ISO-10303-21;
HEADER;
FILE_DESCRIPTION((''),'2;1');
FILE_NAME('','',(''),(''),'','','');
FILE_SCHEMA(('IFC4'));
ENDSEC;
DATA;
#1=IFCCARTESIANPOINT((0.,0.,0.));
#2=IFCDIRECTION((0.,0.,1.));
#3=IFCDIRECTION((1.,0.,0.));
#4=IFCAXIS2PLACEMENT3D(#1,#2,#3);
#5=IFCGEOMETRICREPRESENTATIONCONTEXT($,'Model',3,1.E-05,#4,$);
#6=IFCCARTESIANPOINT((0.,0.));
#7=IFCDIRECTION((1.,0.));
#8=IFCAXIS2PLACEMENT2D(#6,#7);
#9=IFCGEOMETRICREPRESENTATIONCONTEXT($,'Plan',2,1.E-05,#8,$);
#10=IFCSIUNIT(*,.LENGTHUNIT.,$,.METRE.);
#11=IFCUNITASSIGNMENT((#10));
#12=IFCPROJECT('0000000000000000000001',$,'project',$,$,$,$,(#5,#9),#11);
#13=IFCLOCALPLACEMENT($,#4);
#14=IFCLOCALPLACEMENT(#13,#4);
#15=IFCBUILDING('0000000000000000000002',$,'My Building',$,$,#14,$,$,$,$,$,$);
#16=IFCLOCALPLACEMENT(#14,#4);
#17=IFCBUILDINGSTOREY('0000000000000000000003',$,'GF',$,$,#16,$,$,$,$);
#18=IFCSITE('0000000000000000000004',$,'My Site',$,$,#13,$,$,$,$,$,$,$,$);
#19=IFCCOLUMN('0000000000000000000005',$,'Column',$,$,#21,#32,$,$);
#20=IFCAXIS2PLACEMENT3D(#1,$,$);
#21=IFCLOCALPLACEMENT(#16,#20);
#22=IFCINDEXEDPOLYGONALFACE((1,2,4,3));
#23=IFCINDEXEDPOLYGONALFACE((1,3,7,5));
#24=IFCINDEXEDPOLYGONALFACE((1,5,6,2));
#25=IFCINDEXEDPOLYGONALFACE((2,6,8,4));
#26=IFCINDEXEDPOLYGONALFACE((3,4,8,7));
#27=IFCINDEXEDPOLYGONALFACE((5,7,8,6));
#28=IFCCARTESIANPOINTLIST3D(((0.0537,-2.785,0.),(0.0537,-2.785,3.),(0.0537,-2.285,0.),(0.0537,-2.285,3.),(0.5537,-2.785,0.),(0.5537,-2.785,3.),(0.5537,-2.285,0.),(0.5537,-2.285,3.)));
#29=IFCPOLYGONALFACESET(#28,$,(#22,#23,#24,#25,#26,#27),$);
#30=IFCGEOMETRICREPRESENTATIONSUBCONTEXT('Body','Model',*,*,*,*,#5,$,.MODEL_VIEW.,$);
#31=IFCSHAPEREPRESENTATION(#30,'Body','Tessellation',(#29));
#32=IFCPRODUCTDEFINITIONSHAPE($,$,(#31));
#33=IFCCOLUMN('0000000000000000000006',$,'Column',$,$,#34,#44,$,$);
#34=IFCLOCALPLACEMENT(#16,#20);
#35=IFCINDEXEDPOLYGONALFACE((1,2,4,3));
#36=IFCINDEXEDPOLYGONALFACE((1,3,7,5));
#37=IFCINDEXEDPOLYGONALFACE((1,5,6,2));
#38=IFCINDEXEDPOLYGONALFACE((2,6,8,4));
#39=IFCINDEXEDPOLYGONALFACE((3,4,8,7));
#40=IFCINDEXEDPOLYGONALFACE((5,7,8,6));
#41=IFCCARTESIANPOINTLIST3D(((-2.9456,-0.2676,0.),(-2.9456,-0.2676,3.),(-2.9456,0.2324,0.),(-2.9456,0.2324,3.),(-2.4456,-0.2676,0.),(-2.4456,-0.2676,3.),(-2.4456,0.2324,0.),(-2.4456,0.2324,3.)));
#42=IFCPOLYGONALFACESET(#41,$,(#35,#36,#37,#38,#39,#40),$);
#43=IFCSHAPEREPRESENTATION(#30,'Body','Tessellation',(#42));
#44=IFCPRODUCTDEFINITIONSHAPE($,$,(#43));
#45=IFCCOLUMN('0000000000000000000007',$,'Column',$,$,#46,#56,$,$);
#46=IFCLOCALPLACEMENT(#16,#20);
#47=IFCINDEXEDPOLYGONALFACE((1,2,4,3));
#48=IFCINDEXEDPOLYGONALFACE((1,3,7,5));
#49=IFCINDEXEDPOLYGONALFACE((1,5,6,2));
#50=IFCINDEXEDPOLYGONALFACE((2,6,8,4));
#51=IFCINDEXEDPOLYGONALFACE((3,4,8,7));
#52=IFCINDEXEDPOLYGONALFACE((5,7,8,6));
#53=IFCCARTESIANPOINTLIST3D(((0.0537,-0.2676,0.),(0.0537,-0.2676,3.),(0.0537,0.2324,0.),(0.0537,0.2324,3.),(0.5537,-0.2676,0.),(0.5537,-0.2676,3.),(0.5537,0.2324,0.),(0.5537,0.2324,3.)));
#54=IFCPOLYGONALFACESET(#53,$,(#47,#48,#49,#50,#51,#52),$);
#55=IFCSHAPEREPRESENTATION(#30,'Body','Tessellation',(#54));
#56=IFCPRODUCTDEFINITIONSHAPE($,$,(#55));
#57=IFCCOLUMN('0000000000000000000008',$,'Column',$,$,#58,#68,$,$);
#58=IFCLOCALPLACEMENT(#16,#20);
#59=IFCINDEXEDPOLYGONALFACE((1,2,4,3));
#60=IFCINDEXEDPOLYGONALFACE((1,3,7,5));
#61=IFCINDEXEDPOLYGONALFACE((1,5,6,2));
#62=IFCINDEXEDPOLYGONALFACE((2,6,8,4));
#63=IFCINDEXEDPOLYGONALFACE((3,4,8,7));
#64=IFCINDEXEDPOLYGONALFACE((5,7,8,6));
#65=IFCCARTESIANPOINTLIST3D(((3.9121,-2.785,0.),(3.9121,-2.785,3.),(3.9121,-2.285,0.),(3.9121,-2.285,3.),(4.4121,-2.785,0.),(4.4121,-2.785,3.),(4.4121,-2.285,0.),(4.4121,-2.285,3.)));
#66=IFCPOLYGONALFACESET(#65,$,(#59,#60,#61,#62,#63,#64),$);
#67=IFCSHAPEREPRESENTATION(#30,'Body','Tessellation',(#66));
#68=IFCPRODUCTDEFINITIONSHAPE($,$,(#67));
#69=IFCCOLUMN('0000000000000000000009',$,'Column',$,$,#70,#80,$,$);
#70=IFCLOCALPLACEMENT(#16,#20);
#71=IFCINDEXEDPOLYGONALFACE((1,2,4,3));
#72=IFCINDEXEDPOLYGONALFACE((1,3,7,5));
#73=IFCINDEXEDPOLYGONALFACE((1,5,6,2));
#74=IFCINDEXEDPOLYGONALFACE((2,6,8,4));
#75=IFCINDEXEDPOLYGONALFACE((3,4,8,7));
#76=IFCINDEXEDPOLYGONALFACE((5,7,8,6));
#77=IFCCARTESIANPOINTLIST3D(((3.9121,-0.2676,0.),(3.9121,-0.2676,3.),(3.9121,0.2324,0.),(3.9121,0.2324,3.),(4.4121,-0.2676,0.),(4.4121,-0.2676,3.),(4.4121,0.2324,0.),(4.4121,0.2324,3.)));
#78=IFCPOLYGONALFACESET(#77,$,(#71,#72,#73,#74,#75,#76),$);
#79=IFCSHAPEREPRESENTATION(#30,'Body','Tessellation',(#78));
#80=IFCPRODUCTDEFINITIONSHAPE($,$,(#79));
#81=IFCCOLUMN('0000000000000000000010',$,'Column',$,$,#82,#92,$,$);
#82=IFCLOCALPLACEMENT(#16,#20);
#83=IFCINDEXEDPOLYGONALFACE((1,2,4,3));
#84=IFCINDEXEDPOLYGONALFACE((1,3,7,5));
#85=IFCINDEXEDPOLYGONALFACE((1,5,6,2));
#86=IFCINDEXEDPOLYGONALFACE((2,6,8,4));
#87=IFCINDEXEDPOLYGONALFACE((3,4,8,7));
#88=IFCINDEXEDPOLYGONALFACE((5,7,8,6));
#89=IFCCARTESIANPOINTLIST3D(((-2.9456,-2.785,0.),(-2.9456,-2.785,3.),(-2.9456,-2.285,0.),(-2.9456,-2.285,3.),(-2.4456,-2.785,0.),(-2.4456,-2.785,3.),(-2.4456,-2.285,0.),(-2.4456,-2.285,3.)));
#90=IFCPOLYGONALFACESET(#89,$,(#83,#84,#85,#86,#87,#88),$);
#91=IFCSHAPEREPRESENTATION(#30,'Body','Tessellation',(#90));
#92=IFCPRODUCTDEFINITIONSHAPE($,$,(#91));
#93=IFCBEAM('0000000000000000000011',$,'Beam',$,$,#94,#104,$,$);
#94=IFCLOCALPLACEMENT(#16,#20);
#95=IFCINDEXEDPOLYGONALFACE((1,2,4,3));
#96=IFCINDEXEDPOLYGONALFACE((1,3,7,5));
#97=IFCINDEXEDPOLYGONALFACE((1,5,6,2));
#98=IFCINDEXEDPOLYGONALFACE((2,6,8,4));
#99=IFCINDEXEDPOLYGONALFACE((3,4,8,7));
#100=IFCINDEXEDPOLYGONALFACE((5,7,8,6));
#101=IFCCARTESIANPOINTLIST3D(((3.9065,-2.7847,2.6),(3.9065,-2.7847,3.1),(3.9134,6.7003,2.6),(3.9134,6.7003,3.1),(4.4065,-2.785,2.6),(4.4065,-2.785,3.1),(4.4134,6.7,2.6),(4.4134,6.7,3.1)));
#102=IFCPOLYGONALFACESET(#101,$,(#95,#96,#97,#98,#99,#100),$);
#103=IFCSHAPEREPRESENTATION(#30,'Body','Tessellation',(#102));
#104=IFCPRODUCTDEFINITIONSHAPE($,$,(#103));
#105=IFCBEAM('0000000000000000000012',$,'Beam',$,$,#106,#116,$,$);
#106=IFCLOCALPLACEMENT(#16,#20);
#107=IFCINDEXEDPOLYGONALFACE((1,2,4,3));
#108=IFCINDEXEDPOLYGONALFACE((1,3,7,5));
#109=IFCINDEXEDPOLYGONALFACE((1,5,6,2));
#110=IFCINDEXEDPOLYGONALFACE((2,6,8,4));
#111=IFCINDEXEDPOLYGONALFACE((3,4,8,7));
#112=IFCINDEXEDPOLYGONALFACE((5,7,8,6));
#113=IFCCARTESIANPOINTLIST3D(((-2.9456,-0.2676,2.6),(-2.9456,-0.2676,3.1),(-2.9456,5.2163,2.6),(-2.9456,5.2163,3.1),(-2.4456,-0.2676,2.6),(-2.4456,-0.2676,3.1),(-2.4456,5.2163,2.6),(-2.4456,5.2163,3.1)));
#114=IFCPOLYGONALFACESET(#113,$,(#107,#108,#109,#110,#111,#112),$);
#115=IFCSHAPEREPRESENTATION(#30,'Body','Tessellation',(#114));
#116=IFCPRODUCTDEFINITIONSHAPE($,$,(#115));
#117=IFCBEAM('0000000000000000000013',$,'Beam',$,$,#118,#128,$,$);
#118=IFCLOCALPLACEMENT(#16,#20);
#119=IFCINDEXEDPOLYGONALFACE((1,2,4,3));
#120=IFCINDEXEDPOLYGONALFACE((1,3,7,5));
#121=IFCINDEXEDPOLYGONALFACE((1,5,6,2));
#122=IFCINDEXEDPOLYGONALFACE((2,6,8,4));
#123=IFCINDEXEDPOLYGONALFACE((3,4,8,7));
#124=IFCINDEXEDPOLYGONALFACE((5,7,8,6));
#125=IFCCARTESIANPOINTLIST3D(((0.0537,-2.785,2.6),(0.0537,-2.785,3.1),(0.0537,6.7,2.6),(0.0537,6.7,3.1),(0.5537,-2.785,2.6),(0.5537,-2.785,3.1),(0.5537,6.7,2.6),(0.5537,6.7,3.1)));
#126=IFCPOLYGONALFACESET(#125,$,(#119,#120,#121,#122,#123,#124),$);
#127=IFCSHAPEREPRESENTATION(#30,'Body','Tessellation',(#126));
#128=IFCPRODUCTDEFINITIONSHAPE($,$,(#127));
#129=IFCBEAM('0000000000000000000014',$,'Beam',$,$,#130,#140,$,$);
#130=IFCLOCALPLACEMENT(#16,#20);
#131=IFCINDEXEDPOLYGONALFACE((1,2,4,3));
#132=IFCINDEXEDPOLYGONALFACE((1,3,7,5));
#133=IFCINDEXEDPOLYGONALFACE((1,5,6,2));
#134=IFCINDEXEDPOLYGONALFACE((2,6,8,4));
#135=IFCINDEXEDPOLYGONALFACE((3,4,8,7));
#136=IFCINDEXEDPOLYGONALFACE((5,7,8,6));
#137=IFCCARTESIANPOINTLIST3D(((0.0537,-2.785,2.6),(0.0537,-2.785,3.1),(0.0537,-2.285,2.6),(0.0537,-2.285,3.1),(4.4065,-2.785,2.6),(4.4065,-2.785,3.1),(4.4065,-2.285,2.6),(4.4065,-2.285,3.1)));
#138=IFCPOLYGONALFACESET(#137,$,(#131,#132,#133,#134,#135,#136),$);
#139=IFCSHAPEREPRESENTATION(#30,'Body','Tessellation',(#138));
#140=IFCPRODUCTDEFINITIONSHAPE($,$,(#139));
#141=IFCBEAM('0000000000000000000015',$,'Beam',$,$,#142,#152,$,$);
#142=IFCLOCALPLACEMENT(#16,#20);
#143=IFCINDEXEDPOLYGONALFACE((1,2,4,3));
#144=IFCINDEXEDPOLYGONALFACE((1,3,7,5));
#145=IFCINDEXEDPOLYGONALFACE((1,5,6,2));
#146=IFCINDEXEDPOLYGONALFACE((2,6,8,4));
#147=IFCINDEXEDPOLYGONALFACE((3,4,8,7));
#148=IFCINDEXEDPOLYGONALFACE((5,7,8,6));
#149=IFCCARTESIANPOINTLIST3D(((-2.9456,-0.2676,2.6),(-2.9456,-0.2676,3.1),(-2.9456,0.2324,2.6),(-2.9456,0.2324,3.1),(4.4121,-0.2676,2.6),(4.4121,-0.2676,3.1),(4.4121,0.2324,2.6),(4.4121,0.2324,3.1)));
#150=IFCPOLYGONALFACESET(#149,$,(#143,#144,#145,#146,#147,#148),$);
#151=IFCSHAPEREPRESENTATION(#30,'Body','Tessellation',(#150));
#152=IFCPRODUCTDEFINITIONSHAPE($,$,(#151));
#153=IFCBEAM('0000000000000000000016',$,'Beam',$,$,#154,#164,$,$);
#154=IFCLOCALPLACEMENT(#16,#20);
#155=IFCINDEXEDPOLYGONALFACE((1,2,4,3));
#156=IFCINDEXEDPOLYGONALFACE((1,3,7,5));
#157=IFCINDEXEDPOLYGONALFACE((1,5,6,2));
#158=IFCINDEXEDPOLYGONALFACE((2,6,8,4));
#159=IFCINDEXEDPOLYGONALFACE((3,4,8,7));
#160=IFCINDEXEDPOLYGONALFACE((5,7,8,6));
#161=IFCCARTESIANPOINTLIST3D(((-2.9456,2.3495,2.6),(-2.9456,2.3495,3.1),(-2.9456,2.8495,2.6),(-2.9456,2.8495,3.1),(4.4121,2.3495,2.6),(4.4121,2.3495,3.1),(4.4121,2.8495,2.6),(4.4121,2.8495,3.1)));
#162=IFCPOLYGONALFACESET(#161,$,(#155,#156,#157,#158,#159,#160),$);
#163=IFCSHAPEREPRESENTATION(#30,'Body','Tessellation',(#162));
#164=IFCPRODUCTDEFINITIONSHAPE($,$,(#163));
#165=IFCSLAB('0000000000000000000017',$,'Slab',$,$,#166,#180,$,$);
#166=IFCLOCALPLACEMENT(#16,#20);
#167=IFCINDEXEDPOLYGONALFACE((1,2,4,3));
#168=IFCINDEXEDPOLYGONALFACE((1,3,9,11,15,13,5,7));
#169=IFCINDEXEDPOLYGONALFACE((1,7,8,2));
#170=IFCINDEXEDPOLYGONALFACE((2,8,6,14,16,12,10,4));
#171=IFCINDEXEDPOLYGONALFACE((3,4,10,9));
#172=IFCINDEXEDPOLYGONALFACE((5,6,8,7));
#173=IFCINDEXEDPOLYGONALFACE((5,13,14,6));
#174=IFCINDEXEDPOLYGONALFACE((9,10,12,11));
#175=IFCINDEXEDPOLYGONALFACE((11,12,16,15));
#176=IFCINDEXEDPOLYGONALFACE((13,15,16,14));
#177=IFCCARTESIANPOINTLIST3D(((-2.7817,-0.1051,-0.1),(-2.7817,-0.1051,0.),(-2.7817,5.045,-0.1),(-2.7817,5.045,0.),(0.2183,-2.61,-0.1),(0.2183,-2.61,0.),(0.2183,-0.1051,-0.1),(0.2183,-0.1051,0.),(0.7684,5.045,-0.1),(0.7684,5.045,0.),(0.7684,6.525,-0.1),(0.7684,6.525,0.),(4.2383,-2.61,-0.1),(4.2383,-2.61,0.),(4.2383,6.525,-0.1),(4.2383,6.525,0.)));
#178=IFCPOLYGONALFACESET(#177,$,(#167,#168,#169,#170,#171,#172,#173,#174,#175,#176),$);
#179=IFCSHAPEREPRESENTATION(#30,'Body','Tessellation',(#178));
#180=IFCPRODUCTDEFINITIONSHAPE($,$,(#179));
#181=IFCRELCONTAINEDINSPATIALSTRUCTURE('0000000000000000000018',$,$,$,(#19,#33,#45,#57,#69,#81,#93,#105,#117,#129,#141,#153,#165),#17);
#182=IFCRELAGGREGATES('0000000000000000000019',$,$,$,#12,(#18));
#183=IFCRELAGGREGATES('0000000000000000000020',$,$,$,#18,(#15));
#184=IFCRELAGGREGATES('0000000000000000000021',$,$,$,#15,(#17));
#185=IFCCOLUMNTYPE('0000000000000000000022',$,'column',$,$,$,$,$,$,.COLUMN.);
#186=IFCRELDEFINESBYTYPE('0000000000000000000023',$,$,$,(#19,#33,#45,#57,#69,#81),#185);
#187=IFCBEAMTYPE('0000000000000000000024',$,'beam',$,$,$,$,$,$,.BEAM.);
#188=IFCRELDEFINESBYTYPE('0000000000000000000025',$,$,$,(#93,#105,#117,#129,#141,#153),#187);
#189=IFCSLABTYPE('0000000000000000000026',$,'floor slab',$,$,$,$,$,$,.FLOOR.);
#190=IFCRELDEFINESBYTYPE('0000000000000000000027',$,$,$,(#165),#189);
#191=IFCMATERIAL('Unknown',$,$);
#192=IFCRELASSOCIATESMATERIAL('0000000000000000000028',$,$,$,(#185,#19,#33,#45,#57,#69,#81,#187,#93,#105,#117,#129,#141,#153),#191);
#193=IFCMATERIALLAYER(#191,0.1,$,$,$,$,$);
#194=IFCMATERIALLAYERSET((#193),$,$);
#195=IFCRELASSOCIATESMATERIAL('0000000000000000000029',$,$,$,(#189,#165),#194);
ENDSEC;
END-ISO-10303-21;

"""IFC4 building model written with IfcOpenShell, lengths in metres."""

from ifc_helpers import new_model, si_unit, frame, origin_with_axes, origin_2d_with_axis, place, context, subcontext, project, spatial, indexed_curve, rectangle, outline, extrude, material, layer, layer_set, layer_usage, material_profile, profile_set, profile_usage, type_object, element, save


model = new_model("IFC4")

# Units and contexts
model_context = context("Model", 3, precision=1e-05, world=origin_with_axes())
plan_context = context("Plan", 2, precision=1e-05, world=origin_2d_with_axis())
body_context_1 = subcontext(model_context, "Body", "Model", "MODEL_VIEW")
ifc_project = project(units=[si_unit("LENGTHUNIT", "METRE")], contexts=[model_context, plan_context])

# Site, building, storey
site_placement = place(None, origin_with_axes())
site = spatial("IfcSite", under=ifc_project, at=site_placement, Name="My Site")
building_placement = place(site_placement, origin_with_axes())
building = spatial("IfcBuilding", under=site, at=building_placement, Name="My Building")
storey_placement = place(building_placement, origin_with_axes())
storey = spatial("IfcBuildingStorey", under=building, at=storey_placement, Name="GF")

# Columns
ifc_material = material(Name="Unknown")
ifc_material_profile_1 = material_profile(ifc_material, rectangle(XDim=0.5, YDim=0.5))
ifc_profile_set_1 = profile_set([ifc_material_profile_1])
ifc_profile_usage_1 = profile_usage(ifc_profile_set_1, cardinal=5)
column_type = type_object("IfcColumnType", Name="column", PredefinedType="COLUMN", material=ifc_profile_set_1)
column_1_placement = place(storey_placement, frame((0.3037, -2.535, 0.0), z_axis=(0.0, 0.0, 1.0), x_axis=(1.0, 0.0, 0.0)))
element("IfcColumn", 1, at=column_1_placement, inside=storey, type_object=column_type, material=ifc_profile_usage_1, Name="Column", context=body_context_1, shape_type="SweptSolid", body=[
    extrude(rectangle(XDim=0.5, YDim=0.5), origin_with_axes(), (0.0, 0.0, 1.0), 3.0),
])
ifc_profile_usage_2 = profile_usage(ifc_profile_set_1, cardinal=5)
column_2_placement = place(storey_placement, frame((-2.6956, -0.0176, 0.0), z_axis=(0.0, 0.0, 1.0), x_axis=(1.0, 0.0, 0.0)))
element("IfcColumn", 2, at=column_2_placement, inside=storey, type_object=column_type, material=ifc_profile_usage_2, Name="Column", context=body_context_1, shape_type="SweptSolid", body=[
    extrude(rectangle(XDim=0.5, YDim=0.5), origin_with_axes(), (0.0, 0.0, 1.0), 3.0),
])
ifc_profile_usage_3 = profile_usage(ifc_profile_set_1, cardinal=5)
column_3_placement = place(storey_placement, frame((0.3037, -0.0176, 0.0), z_axis=(0.0, 0.0, 1.0), x_axis=(1.0, 0.0, 0.0)))
element("IfcColumn", 3, at=column_3_placement, inside=storey, type_object=column_type, material=ifc_profile_usage_3, Name="Column", context=body_context_1, shape_type="SweptSolid", body=[
    extrude(rectangle(XDim=0.5, YDim=0.5), origin_with_axes(), (0.0, 0.0, 1.0), 3.0),
])
ifc_profile_usage_4 = profile_usage(ifc_profile_set_1, cardinal=5)
column_4_placement = place(storey_placement, frame((4.1621, -2.535, 0.0), z_axis=(0.0, 0.0, 1.0), x_axis=(1.0, 0.0, 0.0)))
element("IfcColumn", 4, at=column_4_placement, inside=storey, type_object=column_type, material=ifc_profile_usage_4, Name="Column", context=body_context_1, shape_type="SweptSolid", body=[
    extrude(rectangle(XDim=0.5, YDim=0.5), origin_with_axes(), (0.0, 0.0, 1.0), 3.0),
])
ifc_profile_usage_5 = profile_usage(ifc_profile_set_1, cardinal=5)
column_5_placement = place(storey_placement, frame((4.1621, -0.0176, 0.0), z_axis=(0.0, 0.0, 1.0), x_axis=(1.0, 0.0, 0.0)))
element("IfcColumn", 5, at=column_5_placement, inside=storey, type_object=column_type, material=ifc_profile_usage_5, Name="Column", context=body_context_1, shape_type="SweptSolid", body=[
    extrude(rectangle(XDim=0.5, YDim=0.5), origin_with_axes(), (0.0, 0.0, 1.0), 3.0),
])
ifc_profile_usage_6 = profile_usage(ifc_profile_set_1, cardinal=5)
column_6_placement = place(storey_placement, frame((-2.6956, -2.535, 0.0), z_axis=(0.0, 0.0, 1.0), x_axis=(1.0, 0.0, 0.0)))
element("IfcColumn", 6, at=column_6_placement, inside=storey, type_object=column_type, material=ifc_profile_usage_6, Name="Column", context=body_context_1, shape_type="SweptSolid", body=[
    extrude(rectangle(XDim=0.5, YDim=0.5), origin_with_axes(), (0.0, 0.0, 1.0), 3.0),
])

# Beams
ifc_material_profile_2 = material_profile(ifc_material, rectangle(XDim=0.5, YDim=0.5))
ifc_profile_set_2 = profile_set([ifc_material_profile_2])
ifc_profile_usage_7 = profile_usage(ifc_profile_set_2, cardinal=9)
beam_type = type_object("IfcBeamType", Name="beam", PredefinedType="BEAM", material=ifc_profile_set_2)
beam_1_placement = place(storey_placement, frame((4.4065, -2.785, 3.1), z_axis=(0.000725, 1.0, 0.0), x_axis=(-1.0, 0.000725, 0.0)))
element("IfcBeam", 7, at=beam_1_placement, inside=storey, type_object=beam_type, material=ifc_profile_usage_7, Name="Beam", context=body_context_1, shape_type="SweptSolid", body=[
    extrude(rectangle(XDim=0.5, YDim=0.5), frame((0.25, -0.25, 0.0), z_axis=(0.0, 0.0, 1.0), x_axis=(1.0, 0.0, 0.0)), (0.0, 0.0, 1.0), 9.485),
])
ifc_profile_usage_8 = profile_usage(ifc_profile_set_2, cardinal=9)
beam_2_placement = place(storey_placement, frame((-2.4456, -0.2676, 3.1), z_axis=(0.0, 1.0, 0.0), x_axis=(-1.0, 0.0, 0.0)))
element("IfcBeam", 8, at=beam_2_placement, inside=storey, type_object=beam_type, material=ifc_profile_usage_8, Name="Beam", context=body_context_1, shape_type="SweptSolid", body=[
    extrude(rectangle(XDim=0.5, YDim=0.5), frame((0.25, -0.25, 0.0), z_axis=(0.0, 0.0, 1.0), x_axis=(1.0, 0.0, 0.0)), (0.0, 0.0, 1.0), 5.4839),
])
ifc_profile_usage_9 = profile_usage(ifc_profile_set_2, cardinal=9)
beam_3_placement = place(storey_placement, frame((0.5537, -2.785, 3.1), z_axis=(0.0, 1.0, 0.0), x_axis=(-1.0, 0.0, 0.0)))
element("IfcBeam", 9, at=beam_3_placement, inside=storey, type_object=beam_type, material=ifc_profile_usage_9, Name="Beam", context=body_context_1, shape_type="SweptSolid", body=[
    extrude(rectangle(XDim=0.5, YDim=0.5), frame((0.25, -0.25, 0.0), z_axis=(0.0, 0.0, 1.0), x_axis=(1.0, 0.0, 0.0)), (0.0, 0.0, 1.0), 9.485),
])
ifc_profile_usage_10 = profile_usage(ifc_profile_set_2, cardinal=9)
beam_4_placement = place(storey_placement, frame((4.4065, -2.285, 3.1), z_axis=(-1.0, 0.0, 0.0), x_axis=(0.0, -1.0, 0.0)))
element("IfcBeam", 10, at=beam_4_placement, inside=storey, type_object=beam_type, material=ifc_profile_usage_10, Name="Beam", context=body_context_1, shape_type="SweptSolid", body=[
    extrude(rectangle(XDim=0.5, YDim=0.5), frame((0.25, -0.25, 0.0), z_axis=(0.0, 0.0, 1.0), x_axis=(1.0, 0.0, 0.0)), (0.0, 0.0, 1.0), 4.3528),
])
ifc_profile_usage_11 = profile_usage(ifc_profile_set_2, cardinal=9)
beam_5_placement = place(storey_placement, frame((-2.9456, -0.2676, 3.1), z_axis=(1.0, 0.0, 0.0), x_axis=(0.0, 1.0, 0.0)))
element("IfcBeam", 11, at=beam_5_placement, inside=storey, type_object=beam_type, material=ifc_profile_usage_11, Name="Beam", context=body_context_1, shape_type="SweptSolid", body=[
    extrude(rectangle(XDim=0.5, YDim=0.5), frame((0.25, -0.25, 0.0), z_axis=(0.0, 0.0, 1.0), x_axis=(1.0, 0.0, 0.0)), (0.0, 0.0, 1.0), 7.3577),
])
ifc_profile_usage_12 = profile_usage(ifc_profile_set_2, cardinal=9)
beam_6_placement = place(storey_placement, frame((-2.9456, 2.3495, 3.1), z_axis=(1.0, 0.0, 0.0), x_axis=(0.0, 1.0, 0.0)))
element("IfcBeam", 12, at=beam_6_placement, inside=storey, type_object=beam_type, material=ifc_profile_usage_12, Name="Beam", context=body_context_1, shape_type="SweptSolid", body=[
    extrude(rectangle(XDim=0.5, YDim=0.5), frame((0.25, -0.25, 0.0), z_axis=(0.0, 0.0, 1.0), x_axis=(1.0, 0.0, 0.0)), (0.0, 0.0, 1.0), 7.3577),
])

# Slab
ifc_layer_1 = layer(ifc_material, 0.1)
ifc_layer_set_1 = layer_set([ifc_layer_1])
ifc_layer_usage_1 = layer_usage(ifc_layer_set_1, "AXIS3", "POSITIVE", -0.1)
slab_type_1 = type_object("IfcSlabType", Name="floor slab", PredefinedType="FLOOR", material=ifc_layer_set_1)
slab_1_placement = place(storey_placement, frame((4.2383, -2.61, 0.0), z_axis=(0.0, 0.0, 1.0), x_axis=(1.0, 0.0, 0.0)))
element("IfcSlab", 13, at=slab_1_placement, inside=storey, type_object=slab_type_1, material=ifc_layer_usage_1, Name="Slab", context=body_context_1, shape_type="SweptSolid", body=[
    extrude(outline(indexed_curve([(0.0, 0.0), (0.0, 9.135), (-3.47, 9.135), (-3.47, 7.655), (-7.02, 7.655), (-7.02, 2.5049), (-4.02, 2.5049), (-4.02, 0.0), (0.0, 0.0)])), frame((0.0, 0.0, -0.1), z_axis=(0.0, 0.0, 1.0), x_axis=(1.0, 0.0, 0.0)), (0.0, 0.0, 1.0), 0.1),
])

save(model, "model.ifc")
